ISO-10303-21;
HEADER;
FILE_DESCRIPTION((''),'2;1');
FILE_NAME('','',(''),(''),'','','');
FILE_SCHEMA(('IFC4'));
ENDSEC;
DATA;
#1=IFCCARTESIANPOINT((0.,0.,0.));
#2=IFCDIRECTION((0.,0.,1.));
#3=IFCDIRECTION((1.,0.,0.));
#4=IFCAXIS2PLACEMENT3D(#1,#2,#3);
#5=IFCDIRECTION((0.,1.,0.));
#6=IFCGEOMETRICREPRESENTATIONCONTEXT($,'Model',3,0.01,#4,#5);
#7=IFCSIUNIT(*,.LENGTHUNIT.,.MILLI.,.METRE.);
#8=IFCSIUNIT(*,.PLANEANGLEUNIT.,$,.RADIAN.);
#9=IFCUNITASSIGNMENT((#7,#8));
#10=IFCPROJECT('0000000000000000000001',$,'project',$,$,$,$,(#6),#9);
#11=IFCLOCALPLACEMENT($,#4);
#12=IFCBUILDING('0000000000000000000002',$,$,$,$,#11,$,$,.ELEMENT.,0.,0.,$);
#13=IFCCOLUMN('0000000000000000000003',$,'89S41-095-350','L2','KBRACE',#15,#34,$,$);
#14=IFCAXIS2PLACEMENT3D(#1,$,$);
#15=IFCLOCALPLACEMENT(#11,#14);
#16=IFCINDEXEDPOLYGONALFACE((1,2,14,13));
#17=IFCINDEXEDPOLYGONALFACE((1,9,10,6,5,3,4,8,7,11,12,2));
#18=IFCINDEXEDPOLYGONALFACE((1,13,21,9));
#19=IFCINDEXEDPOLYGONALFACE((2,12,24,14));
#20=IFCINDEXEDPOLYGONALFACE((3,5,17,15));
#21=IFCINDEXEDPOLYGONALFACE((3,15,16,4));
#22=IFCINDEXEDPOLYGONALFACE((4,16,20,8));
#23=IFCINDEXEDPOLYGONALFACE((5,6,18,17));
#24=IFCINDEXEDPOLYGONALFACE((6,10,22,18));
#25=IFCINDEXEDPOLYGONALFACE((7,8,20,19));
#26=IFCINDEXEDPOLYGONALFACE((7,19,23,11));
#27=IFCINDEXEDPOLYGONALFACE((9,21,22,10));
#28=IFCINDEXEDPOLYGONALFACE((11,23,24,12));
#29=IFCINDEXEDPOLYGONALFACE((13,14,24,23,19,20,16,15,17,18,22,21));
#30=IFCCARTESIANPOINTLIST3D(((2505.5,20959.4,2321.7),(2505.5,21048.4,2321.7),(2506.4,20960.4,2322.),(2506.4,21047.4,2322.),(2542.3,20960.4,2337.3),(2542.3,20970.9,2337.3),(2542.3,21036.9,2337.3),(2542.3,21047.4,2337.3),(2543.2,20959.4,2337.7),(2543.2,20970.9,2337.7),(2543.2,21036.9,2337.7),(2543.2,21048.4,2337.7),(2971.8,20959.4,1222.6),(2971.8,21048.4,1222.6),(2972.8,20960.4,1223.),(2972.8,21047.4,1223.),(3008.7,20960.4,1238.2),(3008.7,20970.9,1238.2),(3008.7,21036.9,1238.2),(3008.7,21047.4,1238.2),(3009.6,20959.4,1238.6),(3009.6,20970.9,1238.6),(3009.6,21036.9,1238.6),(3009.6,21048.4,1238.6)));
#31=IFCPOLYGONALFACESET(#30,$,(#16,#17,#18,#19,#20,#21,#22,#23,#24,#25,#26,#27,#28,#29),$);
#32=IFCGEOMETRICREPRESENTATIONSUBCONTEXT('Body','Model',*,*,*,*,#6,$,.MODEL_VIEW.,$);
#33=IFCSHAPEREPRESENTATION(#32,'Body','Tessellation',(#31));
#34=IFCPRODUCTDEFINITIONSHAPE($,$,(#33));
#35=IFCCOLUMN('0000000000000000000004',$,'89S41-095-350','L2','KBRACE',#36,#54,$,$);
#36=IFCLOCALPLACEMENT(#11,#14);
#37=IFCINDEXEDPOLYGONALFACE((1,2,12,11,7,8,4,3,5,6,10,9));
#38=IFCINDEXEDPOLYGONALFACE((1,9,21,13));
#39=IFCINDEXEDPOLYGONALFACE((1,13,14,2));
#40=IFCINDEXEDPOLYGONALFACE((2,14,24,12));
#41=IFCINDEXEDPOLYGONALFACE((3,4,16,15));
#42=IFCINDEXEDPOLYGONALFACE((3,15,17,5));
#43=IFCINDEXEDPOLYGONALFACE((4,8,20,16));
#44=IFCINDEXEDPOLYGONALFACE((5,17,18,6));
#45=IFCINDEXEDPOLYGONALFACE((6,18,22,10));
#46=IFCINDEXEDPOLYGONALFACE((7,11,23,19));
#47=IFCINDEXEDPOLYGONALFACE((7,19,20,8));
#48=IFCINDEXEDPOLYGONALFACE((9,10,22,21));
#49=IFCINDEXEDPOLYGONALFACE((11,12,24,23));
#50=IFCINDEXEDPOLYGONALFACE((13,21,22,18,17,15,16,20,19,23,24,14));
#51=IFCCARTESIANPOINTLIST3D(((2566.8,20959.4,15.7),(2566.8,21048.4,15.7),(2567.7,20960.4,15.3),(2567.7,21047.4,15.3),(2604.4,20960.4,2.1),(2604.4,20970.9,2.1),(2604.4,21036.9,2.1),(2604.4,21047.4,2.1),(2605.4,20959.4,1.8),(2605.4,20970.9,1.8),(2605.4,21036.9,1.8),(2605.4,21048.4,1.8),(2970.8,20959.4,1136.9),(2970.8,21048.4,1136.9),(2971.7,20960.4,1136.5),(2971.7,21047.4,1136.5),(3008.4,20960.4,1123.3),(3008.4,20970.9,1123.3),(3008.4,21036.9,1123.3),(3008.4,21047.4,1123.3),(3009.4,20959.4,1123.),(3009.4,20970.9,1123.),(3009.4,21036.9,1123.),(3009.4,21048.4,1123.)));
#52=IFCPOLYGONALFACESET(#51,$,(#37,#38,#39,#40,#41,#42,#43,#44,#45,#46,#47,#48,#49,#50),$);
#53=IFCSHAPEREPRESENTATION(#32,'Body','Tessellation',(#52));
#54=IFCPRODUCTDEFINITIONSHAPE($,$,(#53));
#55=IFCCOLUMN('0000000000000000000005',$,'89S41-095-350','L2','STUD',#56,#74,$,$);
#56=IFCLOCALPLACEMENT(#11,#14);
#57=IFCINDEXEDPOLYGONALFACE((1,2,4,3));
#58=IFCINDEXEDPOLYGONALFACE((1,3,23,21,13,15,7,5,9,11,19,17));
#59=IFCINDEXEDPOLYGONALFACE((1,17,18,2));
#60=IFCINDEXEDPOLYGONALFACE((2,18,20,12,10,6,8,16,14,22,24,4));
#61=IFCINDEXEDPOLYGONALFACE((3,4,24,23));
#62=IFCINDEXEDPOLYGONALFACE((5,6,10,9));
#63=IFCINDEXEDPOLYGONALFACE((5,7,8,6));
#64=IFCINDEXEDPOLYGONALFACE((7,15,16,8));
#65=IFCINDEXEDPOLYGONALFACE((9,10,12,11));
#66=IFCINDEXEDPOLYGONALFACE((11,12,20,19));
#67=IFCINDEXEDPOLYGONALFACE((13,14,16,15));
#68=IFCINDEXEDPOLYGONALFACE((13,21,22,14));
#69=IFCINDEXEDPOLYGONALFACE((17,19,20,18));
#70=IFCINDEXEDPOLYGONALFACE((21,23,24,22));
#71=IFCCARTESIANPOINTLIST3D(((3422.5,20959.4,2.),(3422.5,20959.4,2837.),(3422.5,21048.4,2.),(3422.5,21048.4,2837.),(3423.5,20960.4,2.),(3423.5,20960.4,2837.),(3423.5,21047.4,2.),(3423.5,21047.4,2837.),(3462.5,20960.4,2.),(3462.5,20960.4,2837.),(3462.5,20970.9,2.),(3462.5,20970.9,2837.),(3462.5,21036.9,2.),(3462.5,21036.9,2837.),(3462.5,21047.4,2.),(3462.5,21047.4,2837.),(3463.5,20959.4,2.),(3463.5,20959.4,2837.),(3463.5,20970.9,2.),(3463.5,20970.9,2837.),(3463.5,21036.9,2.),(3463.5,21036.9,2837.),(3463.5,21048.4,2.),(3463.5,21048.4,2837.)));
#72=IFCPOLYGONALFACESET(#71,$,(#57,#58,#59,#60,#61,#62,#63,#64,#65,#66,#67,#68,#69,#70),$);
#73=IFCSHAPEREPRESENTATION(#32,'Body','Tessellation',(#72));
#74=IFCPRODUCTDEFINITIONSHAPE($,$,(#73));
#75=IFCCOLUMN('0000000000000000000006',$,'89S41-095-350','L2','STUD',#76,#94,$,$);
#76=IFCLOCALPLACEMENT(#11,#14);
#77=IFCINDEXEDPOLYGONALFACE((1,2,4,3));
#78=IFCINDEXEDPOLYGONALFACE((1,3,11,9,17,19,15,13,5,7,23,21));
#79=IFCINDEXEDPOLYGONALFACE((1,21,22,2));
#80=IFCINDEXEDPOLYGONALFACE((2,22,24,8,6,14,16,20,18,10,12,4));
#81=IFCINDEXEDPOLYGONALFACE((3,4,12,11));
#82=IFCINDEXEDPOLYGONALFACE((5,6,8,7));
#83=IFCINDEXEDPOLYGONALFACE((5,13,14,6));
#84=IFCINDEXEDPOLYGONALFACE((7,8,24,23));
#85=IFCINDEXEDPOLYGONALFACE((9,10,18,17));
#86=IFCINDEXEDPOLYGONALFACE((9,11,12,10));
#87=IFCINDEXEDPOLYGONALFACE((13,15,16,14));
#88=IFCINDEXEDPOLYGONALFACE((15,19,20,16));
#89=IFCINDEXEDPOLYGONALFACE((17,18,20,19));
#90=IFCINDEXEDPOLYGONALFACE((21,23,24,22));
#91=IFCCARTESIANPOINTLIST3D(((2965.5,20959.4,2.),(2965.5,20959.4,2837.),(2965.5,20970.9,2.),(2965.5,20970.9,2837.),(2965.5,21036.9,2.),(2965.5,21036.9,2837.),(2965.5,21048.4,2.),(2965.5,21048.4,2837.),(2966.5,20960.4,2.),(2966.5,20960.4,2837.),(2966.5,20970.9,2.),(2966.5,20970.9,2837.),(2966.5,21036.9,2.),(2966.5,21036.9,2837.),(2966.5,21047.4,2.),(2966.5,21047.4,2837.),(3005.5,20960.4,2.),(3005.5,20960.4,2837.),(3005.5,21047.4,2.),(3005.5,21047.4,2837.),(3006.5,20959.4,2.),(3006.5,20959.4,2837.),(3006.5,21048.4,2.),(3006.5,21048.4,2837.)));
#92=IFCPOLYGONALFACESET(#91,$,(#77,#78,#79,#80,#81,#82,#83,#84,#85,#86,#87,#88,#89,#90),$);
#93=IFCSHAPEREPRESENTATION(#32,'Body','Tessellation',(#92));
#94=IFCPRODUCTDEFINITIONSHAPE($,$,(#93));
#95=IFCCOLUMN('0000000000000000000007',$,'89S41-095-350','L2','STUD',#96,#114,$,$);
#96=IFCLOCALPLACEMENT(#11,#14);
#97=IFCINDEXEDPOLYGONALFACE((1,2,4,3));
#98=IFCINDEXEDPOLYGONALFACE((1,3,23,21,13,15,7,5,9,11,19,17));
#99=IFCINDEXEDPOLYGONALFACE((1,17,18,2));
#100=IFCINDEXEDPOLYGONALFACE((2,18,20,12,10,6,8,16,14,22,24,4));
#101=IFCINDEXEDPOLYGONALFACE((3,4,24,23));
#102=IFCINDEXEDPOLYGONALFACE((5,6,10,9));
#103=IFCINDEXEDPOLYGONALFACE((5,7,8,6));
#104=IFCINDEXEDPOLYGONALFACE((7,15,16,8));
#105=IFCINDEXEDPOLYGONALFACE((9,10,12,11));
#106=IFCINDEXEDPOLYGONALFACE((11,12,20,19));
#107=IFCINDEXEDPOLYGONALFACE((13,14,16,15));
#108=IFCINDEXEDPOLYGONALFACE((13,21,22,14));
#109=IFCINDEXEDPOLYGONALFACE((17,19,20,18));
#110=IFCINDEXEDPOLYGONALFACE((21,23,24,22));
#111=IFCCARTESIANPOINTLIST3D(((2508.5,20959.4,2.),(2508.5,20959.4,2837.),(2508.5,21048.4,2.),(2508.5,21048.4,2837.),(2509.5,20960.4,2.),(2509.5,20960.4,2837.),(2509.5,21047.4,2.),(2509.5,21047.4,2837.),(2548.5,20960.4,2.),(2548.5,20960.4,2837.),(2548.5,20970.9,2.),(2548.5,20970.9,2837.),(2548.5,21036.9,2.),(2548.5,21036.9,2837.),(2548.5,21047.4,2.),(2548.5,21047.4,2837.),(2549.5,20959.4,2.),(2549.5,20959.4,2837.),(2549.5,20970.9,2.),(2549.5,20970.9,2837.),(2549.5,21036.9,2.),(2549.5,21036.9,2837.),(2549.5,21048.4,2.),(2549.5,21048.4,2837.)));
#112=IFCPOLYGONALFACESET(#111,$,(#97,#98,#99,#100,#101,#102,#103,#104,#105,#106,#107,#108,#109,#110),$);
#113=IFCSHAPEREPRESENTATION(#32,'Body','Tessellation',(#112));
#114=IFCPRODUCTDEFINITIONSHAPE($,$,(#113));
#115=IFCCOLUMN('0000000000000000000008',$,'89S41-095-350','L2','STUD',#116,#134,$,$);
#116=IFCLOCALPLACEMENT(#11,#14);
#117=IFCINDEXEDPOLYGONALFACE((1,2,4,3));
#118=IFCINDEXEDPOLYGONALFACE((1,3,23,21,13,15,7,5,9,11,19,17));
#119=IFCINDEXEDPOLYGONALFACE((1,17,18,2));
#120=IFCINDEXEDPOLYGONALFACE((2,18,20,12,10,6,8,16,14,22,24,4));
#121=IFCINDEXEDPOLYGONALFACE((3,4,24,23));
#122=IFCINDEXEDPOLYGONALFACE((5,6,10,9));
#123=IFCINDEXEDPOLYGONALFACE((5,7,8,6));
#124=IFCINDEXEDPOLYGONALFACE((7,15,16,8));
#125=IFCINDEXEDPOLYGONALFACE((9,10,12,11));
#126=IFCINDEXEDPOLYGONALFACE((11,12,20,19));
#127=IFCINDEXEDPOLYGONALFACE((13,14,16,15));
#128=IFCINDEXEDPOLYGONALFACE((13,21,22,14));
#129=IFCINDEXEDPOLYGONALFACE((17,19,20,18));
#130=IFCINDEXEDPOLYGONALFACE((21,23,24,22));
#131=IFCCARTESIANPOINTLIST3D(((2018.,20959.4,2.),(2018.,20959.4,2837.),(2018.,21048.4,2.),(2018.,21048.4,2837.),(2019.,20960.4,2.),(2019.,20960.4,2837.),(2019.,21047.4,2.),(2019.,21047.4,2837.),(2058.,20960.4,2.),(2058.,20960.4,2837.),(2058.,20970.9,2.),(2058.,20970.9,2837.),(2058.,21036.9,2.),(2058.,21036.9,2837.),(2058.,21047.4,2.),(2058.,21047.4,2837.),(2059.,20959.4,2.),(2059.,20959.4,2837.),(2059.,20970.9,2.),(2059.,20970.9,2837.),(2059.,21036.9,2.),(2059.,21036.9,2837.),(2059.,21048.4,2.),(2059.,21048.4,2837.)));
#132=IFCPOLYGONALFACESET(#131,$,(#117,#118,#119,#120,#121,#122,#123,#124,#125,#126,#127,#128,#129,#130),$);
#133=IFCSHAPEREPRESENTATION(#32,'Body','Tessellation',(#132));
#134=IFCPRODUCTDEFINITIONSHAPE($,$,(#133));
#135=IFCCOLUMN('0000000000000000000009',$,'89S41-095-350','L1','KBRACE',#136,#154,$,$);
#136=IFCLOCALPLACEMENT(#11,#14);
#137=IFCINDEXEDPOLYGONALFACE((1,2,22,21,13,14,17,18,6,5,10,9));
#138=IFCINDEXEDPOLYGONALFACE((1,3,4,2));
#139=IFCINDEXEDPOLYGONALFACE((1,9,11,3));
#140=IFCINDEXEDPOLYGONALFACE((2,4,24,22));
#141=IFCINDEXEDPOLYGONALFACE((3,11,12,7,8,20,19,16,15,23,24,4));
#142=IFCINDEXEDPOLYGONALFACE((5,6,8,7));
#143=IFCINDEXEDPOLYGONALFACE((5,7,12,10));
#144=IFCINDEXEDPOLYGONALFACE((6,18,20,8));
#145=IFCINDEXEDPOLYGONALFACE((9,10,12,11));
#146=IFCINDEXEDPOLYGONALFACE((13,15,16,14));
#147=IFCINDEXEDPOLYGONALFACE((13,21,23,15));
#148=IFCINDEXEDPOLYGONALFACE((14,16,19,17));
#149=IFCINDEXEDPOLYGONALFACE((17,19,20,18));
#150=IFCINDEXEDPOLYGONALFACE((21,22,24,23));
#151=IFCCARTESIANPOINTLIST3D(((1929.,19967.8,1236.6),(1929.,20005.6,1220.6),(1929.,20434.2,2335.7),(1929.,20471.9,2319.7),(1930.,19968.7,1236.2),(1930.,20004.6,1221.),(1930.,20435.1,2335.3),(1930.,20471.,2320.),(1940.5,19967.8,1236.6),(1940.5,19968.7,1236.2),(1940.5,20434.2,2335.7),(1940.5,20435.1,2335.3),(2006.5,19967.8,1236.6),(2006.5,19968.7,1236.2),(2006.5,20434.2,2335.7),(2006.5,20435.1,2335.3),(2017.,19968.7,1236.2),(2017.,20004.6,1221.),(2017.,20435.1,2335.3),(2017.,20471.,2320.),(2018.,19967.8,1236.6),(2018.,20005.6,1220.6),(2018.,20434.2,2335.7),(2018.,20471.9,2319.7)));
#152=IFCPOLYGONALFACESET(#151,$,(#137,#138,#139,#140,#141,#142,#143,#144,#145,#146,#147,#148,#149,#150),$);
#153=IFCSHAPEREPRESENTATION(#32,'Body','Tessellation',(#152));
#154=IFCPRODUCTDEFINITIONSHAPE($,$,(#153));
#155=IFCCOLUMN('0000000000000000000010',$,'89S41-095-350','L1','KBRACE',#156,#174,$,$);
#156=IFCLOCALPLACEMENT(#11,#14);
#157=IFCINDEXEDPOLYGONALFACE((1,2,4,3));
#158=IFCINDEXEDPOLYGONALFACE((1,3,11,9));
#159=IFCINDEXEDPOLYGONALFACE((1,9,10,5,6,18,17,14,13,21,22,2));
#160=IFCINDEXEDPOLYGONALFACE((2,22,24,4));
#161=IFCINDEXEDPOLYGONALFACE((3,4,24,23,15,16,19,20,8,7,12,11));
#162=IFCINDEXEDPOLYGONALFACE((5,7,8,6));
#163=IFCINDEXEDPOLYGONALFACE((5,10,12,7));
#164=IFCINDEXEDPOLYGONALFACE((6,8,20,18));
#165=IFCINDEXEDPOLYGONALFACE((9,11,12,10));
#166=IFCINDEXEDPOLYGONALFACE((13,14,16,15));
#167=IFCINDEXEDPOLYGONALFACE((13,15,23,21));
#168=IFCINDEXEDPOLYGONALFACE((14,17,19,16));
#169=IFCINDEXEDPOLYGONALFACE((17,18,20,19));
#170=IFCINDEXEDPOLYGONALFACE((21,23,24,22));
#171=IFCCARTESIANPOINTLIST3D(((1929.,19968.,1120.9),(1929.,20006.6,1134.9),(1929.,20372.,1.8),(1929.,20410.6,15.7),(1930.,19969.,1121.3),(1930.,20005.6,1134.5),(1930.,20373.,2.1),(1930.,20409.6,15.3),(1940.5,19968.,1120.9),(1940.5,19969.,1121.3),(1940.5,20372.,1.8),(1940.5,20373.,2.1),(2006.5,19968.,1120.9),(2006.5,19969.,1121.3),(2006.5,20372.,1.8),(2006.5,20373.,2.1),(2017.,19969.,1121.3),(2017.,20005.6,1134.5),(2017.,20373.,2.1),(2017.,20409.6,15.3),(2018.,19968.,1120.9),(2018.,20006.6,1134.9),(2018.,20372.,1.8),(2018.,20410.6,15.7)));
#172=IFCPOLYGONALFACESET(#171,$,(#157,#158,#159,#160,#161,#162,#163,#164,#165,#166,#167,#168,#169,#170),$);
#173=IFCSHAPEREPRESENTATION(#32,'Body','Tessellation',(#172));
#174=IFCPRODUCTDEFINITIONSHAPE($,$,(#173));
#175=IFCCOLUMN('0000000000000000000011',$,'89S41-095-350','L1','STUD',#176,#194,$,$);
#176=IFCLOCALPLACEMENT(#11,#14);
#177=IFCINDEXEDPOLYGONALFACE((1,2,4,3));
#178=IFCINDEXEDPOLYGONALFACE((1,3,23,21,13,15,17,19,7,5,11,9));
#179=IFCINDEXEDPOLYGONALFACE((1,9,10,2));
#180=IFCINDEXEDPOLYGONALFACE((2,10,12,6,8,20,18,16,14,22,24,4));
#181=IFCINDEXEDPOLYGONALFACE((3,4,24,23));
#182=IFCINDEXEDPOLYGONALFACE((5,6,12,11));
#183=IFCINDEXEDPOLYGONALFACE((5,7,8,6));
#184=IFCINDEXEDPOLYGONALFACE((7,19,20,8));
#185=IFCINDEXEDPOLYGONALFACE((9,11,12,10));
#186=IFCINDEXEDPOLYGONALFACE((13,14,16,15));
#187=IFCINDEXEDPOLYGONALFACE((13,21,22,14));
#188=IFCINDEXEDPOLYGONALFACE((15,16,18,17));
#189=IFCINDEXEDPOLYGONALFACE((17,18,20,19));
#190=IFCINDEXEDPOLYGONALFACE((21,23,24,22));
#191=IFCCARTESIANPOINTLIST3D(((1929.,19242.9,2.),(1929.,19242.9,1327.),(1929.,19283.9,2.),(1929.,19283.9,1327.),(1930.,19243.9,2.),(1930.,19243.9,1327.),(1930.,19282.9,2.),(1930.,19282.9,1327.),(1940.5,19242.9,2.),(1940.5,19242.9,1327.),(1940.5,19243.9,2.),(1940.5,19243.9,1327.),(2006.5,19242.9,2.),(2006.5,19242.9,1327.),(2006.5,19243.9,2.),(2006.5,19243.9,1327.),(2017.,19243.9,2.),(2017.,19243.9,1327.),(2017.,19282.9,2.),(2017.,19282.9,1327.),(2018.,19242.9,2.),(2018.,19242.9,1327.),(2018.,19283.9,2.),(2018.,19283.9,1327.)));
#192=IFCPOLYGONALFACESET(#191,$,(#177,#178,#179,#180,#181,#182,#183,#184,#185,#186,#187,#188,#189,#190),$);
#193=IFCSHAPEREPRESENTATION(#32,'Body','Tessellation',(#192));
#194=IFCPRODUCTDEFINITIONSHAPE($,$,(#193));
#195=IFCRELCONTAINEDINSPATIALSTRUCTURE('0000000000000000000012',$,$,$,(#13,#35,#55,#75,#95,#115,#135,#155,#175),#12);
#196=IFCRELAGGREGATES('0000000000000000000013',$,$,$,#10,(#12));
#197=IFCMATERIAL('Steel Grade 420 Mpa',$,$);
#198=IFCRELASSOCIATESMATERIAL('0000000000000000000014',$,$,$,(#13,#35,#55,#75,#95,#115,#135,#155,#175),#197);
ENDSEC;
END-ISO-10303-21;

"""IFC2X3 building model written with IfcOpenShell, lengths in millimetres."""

from ifc_helpers import new_model, si_unit, direction, frame, origin, origin_with_axes, origin_2d_with_axis, place, context, subcontext, project, spatial, c_section, extrude, source, transform, mapped, material, element, save


model = new_model("IFC2X3")

# Units and contexts
model_context = context("Model", 3, precision=0.01, world=origin_with_axes(), true_north=direction((0.0, 1.0, 0.0)))
body_context = subcontext(model_context, "Body", "Model", "MODEL_VIEW")
ifc_project = project(units=[si_unit("LENGTHUNIT", "METRE", prefix="MILLI"), si_unit("PLANEANGLEUNIT", "RADIAN")], contexts=[model_context])

# Building
building_placement = place(None, origin_with_axes())
building = spatial("IfcBuilding", under=ifc_project, at=building_placement, CompositionType="ELEMENT", ElevationOfRefHeight=0.0, ElevationOfTerrain=0.0)

# Columns
ifc_material = material(Name="Steel Grade 420 Mpa")
shared_shape_1 = source(origin(), body_context, "Body", "SweptSolid", [
    extrude(c_section(Depth=89.0, Width=41.0, WallThickness=1.0, Girth=11.5, at=origin_2d_with_axis()), origin_with_axes(), (0.0, 0.0, 1.0), 1193.9),
])
column_1_placement = place(None, frame((2990.7, 21003.9, 1230.6), z_axis=(-0.390616, 0.0, 0.920554), x_axis=(0.920554, 0.0, 0.390616)))
element("IfcColumn", 1, at=column_1_placement, inside=building, material=ifc_material, Name="89S41-095-350", Description="L2", ObjectType="KBRACE", context=body_context, shape_type="MappedRepresentation", body=[
    mapped(shared_shape_1, transform((0.0, 0.0, 0.0), scale=1.0)),
])
shared_shape_2 = source(origin(), body_context, "Body", "SweptSolid", [
    extrude(c_section(Depth=89.0, Width=41.0, WallThickness=1.0, Girth=11.5, at=origin_2d_with_axis()), origin_with_axes(), (0.0, 0.0, 1.0), 1191.8),
])
column_2_placement = place(None, frame((2586.1, 21003.9, 8.7), z_axis=(0.338991, 0.0, 0.94079), x_axis=(0.94079, 0.0, -0.338991)))
element("IfcColumn", 2, at=column_2_placement, inside=building, material=ifc_material, Name="89S41-095-350", Description="L2", ObjectType="KBRACE", context=body_context, shape_type="MappedRepresentation", body=[
    mapped(shared_shape_2, transform((0.0, 0.0, 0.0), scale=1.0)),
])
shared_shape_3 = source(origin(), body_context, "Body", "SweptSolid", [
    extrude(c_section(Depth=89.0, Width=41.0, WallThickness=1.0, Girth=11.5, at=origin_2d_with_axis()), origin_with_axes(), (0.0, 0.0, 1.0), 2835.0),
])
column_3_placement = place(None, frame((3443.0, 21003.9, 2.0), z_axis=(0.0, 0.0, 1.0), x_axis=(1.0, 0.0, 0.0)))
element("IfcColumn", 3, at=column_3_placement, inside=building, material=ifc_material, Name="89S41-095-350", Description="L2", ObjectType="STUD", context=body_context, shape_type="MappedRepresentation", body=[
    mapped(shared_shape_3, transform((0.0, 0.0, 0.0), scale=1.0)),
])
shared_shape_4 = source(origin(), body_context, "Body", "SweptSolid", [
    extrude(c_section(Depth=89.0, Width=41.0, WallThickness=1.0, Girth=11.5, at=origin_2d_with_axis()), origin_with_axes(), (0.0, 0.0, 1.0), 2835.0),
])
column_4_placement = place(None, frame((2986.0, 21003.9, 2.0), z_axis=(0.0, 0.0, 1.0), x_axis=(-1.0, 0.0, 0.0)))
element("IfcColumn", 4, at=column_4_placement, inside=building, material=ifc_material, Name="89S41-095-350", Description="L2", ObjectType="STUD", context=body_context, shape_type="MappedRepresentation", body=[
    mapped(shared_shape_4, transform((0.0, 0.0, 0.0), scale=1.0)),
])
shared_shape_5 = source(origin(), body_context, "Body", "SweptSolid", [
    extrude(c_section(Depth=89.0, Width=41.0, WallThickness=1.0, Girth=11.5, at=origin_2d_with_axis()), origin_with_axes(), (0.0, 0.0, 1.0), 2835.0),
])
column_5_placement = place(None, frame((2529.0, 21003.9, 2.0), z_axis=(0.0, 0.0, 1.0), x_axis=(1.0, 0.0, 0.0)))
element("IfcColumn", 5, at=column_5_placement, inside=building, material=ifc_material, Name="89S41-095-350", Description="L2", ObjectType="STUD", context=body_context, shape_type="MappedRepresentation", body=[
    mapped(shared_shape_5, transform((0.0, 0.0, 0.0), scale=1.0)),
])
shared_shape_6 = source(origin(), body_context, "Body", "SweptSolid", [
    extrude(c_section(Depth=89.0, Width=41.0, WallThickness=1.0, Girth=11.5, at=origin_2d_with_axis()), origin_with_axes(), (0.0, 0.0, 1.0), 2835.0),
])
column_6_placement = place(None, frame((2038.5, 21003.9, 2.0), z_axis=(0.0, 0.0, 1.0), x_axis=(1.0, 0.0, 0.0)))
element("IfcColumn", 6, at=column_6_placement, inside=building, material=ifc_material, Name="89S41-095-350", Description="L2", ObjectType="STUD", context=body_context, shape_type="MappedRepresentation", body=[
    mapped(shared_shape_6, transform((0.0, 0.0, 0.0), scale=1.0)),
])
shared_shape_7 = source(origin(), body_context, "Body", "SweptSolid", [
    extrude(c_section(Depth=89.0, Width=41.0, WallThickness=1.0, Girth=11.5, at=origin_2d_with_axis()), origin_with_axes(), (0.0, 0.0, 1.0), 1193.9),
])
column_7_placement = place(None, frame((1973.5, 19986.7, 1228.6), z_axis=(0.0, 0.390616, 0.920554), x_axis=(0.0, -0.920554, 0.390616)))
element("IfcColumn", 7, at=column_7_placement, inside=building, material=ifc_material, Name="89S41-095-350", Description="L1", ObjectType="KBRACE", context=body_context, shape_type="MappedRepresentation", body=[
    mapped(shared_shape_7, transform((0.0, 0.0, 0.0), scale=1.0)),
])
shared_shape_8 = source(origin(), body_context, "Body", "SweptSolid", [
    extrude(c_section(Depth=89.0, Width=41.0, WallThickness=1.0, Girth=11.5, at=origin_2d_with_axis()), origin_with_axes(), (0.0, 0.0, 1.0), 1189.9),
])
column_8_placement = place(None, frame((1973.5, 20391.3, 8.7), z_axis=(0.0, -0.339538, 0.940592), x_axis=(0.0, -0.940592, -0.339538)))
element("IfcColumn", 8, at=column_8_placement, inside=building, material=ifc_material, Name="89S41-095-350", Description="L1", ObjectType="KBRACE", context=body_context, shape_type="MappedRepresentation", body=[
    mapped(shared_shape_8, transform((0.0, 0.0, 0.0), scale=1.0)),
])
shared_shape_9 = source(origin(), body_context, "Body", "SweptSolid", [
    extrude(c_section(Depth=89.0, Width=41.0, WallThickness=1.0, Girth=11.5, at=origin_2d_with_axis()), origin_with_axes(), (0.0, 0.0, 1.0), 1325.0),
])
column_9_placement = place(None, frame((1973.5, 19263.4, 2.0), z_axis=(0.0, 0.0, 1.0), x_axis=(0.0, -1.0, 0.0)))
element("IfcColumn", 9, at=column_9_placement, inside=building, material=ifc_material, Name="89S41-095-350", Description="L1", ObjectType="STUD", context=body_context, shape_type="MappedRepresentation", body=[
    mapped(shared_shape_9, transform((0.0, 0.0, 0.0), scale=1.0)),
])

save(model, "model.ifc")
